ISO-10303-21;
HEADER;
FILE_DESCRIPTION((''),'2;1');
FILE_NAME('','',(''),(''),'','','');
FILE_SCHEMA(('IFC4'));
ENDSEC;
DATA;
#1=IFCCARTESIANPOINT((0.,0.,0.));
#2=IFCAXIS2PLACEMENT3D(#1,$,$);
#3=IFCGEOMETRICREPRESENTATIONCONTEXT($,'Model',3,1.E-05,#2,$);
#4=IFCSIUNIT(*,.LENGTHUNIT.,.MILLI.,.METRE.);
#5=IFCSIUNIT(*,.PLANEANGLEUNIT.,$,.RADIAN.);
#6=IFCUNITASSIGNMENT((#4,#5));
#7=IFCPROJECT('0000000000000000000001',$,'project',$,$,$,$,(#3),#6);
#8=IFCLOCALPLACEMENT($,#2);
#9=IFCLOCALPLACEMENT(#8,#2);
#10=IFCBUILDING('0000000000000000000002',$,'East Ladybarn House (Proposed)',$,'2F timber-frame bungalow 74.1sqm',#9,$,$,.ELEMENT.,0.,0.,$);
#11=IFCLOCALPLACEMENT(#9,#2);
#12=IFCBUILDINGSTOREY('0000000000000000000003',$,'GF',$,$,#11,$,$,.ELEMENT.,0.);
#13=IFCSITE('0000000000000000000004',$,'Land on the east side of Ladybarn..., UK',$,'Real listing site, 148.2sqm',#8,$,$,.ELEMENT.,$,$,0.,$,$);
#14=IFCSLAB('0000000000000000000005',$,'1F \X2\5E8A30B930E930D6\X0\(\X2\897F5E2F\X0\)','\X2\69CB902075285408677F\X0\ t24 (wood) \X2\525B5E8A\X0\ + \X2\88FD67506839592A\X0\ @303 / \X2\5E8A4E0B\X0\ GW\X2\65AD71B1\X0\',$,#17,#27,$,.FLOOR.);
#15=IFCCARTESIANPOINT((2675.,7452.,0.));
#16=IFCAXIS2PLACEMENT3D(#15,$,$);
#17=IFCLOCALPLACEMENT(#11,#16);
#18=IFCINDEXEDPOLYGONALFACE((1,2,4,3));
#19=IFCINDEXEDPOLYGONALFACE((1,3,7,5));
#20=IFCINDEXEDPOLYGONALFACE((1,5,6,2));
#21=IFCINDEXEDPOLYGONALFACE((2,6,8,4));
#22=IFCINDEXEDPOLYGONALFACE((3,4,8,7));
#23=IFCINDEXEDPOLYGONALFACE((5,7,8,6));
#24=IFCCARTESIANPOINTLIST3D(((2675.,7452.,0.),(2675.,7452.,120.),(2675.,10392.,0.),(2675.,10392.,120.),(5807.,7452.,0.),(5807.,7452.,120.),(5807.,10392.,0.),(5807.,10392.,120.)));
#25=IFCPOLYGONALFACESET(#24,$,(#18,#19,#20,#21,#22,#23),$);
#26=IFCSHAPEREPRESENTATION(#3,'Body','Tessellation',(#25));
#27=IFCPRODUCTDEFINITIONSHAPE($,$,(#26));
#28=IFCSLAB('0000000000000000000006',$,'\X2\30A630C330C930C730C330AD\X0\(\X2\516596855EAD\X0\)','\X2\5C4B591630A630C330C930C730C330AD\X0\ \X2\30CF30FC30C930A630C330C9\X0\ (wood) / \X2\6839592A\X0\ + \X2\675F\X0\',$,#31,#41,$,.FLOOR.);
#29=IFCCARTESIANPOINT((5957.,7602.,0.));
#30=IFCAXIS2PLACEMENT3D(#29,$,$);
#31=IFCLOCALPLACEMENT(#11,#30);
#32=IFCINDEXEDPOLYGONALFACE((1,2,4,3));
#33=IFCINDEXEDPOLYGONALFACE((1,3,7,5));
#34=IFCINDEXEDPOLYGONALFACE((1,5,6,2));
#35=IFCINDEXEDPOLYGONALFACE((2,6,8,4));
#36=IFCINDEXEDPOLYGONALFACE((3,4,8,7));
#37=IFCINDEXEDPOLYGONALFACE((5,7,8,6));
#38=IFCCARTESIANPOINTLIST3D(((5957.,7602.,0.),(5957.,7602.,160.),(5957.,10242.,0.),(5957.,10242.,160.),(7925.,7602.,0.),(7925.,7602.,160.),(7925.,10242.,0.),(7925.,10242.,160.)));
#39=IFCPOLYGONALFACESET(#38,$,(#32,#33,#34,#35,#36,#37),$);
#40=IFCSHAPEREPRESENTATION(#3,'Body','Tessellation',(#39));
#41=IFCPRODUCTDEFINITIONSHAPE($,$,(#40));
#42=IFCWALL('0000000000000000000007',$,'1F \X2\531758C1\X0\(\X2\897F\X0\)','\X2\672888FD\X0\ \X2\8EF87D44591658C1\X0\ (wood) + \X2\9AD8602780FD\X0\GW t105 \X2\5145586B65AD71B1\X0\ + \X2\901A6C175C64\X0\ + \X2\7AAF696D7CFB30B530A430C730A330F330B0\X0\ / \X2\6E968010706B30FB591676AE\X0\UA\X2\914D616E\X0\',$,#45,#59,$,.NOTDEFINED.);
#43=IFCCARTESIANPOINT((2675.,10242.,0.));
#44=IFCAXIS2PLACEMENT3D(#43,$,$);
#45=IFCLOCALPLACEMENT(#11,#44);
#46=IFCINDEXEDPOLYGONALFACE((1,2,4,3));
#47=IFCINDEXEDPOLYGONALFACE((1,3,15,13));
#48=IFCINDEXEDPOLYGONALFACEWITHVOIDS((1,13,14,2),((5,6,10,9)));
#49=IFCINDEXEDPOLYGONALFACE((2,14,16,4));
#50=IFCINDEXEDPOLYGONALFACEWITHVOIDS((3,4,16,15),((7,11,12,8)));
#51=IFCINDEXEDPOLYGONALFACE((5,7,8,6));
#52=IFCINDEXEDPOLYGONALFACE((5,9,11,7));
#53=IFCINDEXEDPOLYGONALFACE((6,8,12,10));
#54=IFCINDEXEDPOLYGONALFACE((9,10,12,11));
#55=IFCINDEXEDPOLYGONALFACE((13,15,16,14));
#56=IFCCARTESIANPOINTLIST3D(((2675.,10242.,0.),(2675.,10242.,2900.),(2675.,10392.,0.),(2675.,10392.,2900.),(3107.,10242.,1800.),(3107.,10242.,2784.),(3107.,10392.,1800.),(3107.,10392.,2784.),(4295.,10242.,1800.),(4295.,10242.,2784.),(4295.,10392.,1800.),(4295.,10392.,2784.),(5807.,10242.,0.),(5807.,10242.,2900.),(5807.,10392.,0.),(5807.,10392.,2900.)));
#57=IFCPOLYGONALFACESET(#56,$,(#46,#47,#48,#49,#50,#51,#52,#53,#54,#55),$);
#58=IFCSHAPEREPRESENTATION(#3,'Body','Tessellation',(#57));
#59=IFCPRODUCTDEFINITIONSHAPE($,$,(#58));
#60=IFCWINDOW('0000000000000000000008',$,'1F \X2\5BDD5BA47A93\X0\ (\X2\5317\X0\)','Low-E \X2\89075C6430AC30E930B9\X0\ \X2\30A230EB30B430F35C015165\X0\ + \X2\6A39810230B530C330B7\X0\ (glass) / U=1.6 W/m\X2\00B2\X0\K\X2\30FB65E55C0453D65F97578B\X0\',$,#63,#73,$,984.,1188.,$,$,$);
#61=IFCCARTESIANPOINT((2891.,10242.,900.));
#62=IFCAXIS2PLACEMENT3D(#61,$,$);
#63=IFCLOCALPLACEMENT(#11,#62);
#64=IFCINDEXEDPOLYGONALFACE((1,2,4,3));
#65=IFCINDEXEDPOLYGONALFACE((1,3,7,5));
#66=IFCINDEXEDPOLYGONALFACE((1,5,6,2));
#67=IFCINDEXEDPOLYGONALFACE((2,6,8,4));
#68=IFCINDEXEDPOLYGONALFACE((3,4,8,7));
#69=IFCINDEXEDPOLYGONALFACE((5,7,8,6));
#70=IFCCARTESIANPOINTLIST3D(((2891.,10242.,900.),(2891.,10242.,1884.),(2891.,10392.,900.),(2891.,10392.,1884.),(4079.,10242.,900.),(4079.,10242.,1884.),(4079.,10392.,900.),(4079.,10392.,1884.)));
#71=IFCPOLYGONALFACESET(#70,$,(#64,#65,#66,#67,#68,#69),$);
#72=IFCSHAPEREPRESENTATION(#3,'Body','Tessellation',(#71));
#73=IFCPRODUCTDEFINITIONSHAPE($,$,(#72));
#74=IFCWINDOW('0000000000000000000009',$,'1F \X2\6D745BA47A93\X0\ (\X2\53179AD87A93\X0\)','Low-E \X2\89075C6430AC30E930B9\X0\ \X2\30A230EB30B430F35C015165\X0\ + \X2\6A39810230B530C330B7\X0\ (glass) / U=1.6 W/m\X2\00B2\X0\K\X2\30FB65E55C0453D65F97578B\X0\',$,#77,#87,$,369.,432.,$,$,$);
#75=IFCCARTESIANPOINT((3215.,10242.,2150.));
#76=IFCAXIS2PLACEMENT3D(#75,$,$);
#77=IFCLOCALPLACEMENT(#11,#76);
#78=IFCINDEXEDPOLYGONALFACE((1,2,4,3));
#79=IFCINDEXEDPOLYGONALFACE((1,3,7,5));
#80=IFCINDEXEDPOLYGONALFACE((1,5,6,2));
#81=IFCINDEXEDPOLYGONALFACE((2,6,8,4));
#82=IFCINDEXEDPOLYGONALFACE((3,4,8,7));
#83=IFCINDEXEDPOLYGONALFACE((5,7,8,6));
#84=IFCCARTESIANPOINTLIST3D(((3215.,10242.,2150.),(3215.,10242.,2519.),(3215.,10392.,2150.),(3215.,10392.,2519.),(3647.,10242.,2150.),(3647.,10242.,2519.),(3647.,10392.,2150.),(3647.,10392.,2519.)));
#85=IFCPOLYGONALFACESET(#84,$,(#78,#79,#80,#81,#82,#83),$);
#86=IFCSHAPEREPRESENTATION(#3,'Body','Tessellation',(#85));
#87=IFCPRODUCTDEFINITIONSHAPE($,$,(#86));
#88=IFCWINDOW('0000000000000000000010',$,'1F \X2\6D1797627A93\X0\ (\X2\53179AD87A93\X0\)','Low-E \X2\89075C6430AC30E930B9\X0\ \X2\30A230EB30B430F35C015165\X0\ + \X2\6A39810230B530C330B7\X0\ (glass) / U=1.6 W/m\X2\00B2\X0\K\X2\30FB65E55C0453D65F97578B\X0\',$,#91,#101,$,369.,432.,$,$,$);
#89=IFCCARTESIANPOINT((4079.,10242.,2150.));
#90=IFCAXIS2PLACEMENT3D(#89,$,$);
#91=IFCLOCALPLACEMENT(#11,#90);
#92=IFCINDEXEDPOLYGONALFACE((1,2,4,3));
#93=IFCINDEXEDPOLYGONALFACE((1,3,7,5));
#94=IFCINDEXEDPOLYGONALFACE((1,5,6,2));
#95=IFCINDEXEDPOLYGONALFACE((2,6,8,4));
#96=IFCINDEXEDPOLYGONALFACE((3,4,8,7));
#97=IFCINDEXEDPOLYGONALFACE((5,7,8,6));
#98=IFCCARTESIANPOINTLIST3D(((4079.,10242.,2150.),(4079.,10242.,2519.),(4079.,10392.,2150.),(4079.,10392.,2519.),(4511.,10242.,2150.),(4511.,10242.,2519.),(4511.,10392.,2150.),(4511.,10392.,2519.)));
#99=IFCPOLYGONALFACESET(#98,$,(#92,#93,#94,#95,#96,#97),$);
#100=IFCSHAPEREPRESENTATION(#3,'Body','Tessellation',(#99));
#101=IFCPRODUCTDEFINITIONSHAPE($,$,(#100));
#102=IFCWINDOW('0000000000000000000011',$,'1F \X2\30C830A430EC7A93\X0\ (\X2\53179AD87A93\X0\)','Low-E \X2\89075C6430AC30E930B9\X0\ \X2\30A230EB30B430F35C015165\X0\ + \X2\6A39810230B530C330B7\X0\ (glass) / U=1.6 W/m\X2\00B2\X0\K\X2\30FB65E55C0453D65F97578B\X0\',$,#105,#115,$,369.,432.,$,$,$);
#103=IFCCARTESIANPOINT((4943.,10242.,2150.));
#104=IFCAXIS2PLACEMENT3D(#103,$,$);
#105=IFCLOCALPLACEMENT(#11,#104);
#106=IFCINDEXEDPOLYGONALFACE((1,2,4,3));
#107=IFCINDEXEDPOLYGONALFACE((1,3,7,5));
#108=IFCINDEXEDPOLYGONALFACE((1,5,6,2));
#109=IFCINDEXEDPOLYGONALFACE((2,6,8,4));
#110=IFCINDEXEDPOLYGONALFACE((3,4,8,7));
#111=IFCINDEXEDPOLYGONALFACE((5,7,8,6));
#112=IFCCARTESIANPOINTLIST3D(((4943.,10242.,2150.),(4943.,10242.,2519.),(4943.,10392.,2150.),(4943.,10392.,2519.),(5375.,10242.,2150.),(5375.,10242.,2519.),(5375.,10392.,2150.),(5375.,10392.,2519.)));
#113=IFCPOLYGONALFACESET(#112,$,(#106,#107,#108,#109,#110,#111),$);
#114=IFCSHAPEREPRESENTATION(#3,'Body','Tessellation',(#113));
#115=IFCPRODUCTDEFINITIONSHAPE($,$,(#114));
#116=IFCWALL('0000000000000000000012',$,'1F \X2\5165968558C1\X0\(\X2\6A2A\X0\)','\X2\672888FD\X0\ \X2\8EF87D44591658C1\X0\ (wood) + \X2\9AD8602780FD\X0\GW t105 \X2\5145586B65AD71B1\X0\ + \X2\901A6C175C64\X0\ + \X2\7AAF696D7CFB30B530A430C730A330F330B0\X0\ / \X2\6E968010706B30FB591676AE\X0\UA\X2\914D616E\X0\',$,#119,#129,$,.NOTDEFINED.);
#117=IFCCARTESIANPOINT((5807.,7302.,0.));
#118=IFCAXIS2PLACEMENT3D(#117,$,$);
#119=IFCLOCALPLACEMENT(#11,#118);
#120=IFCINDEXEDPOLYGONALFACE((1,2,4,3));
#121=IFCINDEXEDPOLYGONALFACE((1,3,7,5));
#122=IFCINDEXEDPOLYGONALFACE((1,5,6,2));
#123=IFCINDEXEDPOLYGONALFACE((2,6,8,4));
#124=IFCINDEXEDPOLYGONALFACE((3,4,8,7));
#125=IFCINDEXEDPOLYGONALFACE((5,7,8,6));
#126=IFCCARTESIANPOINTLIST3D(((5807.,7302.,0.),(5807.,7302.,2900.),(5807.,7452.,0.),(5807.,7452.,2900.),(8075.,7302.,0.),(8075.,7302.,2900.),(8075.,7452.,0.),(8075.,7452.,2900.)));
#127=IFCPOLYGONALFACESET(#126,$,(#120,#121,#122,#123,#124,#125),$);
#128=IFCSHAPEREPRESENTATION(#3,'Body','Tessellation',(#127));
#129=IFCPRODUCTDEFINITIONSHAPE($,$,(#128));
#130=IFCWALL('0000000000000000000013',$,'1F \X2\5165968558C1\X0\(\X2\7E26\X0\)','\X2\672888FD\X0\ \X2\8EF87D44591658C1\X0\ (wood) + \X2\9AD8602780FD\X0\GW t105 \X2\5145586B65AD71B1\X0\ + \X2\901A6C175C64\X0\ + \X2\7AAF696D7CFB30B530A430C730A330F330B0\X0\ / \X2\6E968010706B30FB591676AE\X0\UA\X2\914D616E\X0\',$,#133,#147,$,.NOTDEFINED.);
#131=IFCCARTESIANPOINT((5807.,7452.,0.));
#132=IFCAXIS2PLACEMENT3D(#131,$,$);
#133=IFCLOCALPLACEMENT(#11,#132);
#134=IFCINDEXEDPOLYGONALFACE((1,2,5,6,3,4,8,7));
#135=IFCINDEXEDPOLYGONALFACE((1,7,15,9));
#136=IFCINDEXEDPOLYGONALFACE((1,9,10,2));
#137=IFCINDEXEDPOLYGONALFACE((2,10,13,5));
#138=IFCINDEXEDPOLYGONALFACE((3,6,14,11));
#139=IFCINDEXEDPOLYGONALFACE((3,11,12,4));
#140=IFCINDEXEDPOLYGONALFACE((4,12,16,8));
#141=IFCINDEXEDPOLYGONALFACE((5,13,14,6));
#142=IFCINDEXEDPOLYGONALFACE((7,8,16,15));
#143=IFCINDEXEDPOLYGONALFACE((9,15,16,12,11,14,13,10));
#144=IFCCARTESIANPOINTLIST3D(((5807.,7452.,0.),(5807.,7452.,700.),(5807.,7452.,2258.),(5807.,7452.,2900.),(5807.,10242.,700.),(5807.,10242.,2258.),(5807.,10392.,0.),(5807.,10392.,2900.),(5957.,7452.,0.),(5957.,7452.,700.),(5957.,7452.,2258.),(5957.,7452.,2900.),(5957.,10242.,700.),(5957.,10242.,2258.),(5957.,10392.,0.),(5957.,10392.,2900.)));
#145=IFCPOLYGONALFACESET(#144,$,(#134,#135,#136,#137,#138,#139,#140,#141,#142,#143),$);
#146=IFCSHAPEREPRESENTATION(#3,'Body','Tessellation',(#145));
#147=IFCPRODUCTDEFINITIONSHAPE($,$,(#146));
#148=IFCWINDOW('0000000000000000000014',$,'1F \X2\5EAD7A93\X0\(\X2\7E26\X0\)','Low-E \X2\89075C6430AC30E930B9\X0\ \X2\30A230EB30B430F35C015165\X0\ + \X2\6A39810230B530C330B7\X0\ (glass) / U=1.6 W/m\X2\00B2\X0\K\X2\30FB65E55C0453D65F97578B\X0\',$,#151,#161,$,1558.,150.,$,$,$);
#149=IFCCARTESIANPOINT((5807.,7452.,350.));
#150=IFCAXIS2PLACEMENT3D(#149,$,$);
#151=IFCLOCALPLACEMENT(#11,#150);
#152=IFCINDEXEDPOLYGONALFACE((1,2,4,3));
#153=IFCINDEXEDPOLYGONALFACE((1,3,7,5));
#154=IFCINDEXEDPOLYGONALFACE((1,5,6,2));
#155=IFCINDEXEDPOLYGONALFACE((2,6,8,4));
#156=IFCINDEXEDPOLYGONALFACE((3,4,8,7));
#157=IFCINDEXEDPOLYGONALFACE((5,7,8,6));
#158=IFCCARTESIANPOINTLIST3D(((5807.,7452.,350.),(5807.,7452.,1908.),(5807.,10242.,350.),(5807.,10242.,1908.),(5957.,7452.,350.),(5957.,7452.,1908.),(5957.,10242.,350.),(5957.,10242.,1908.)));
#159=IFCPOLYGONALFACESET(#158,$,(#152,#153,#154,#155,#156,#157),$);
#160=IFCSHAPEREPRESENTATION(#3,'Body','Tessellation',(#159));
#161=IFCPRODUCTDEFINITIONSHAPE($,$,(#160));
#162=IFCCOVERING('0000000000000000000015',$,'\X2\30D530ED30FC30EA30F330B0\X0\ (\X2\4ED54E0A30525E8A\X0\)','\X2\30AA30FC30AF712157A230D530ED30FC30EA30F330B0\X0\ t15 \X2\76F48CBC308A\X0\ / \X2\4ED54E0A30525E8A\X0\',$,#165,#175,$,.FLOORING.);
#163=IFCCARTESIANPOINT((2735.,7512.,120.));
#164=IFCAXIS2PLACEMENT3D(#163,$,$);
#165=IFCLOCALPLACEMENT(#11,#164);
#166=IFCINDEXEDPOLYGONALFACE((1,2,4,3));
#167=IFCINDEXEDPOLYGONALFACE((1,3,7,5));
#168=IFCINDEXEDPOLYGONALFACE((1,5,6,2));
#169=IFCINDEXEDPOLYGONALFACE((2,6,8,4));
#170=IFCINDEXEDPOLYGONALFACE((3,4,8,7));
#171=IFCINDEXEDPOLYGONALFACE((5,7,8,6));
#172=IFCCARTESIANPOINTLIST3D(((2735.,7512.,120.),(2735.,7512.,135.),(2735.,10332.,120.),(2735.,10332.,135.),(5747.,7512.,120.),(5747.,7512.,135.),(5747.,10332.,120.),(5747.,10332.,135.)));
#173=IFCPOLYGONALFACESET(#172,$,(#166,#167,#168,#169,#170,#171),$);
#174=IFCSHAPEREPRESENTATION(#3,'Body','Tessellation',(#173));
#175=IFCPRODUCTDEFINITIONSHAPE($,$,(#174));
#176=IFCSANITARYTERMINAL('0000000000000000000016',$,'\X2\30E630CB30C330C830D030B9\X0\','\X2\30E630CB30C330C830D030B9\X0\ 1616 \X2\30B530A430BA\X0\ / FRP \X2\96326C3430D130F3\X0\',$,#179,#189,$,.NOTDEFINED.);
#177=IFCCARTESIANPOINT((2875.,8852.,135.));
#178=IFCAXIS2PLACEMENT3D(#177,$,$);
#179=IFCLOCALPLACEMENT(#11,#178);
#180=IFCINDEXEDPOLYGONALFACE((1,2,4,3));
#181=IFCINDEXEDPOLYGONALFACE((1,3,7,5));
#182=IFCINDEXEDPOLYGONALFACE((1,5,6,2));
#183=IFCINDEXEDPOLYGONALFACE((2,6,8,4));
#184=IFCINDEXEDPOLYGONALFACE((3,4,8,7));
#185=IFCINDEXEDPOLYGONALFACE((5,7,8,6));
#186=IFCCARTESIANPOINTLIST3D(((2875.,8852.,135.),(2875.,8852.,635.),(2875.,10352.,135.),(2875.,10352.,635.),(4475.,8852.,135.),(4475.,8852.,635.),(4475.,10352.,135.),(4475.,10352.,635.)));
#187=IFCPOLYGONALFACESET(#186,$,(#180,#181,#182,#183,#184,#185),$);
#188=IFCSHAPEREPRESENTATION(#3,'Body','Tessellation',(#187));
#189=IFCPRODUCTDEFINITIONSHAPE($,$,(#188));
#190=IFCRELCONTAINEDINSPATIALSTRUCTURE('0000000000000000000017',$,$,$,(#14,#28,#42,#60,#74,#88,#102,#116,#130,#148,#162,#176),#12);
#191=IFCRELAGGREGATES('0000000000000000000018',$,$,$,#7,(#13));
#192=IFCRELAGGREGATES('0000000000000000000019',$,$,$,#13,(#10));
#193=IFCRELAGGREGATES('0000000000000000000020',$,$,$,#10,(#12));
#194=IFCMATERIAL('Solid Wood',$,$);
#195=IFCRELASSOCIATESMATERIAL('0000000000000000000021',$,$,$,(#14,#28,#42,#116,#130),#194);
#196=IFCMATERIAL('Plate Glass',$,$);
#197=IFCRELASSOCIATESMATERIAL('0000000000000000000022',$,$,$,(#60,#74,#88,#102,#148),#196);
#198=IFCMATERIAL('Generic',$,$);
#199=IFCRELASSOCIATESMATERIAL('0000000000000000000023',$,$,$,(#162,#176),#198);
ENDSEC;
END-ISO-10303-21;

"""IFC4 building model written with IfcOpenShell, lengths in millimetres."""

from ifc_helpers import new_model, si_unit, frame, frame_2d, origin, place, context, project, spatial, rectangle, extrude, material, element, fill, save


model = new_model("IFC4")

# Units and contexts
model_context = context("Model", 3, precision=1e-05, world=origin())
ifc_project = project(units=[si_unit("LENGTHUNIT", "METRE", prefix="MILLI"), si_unit("PLANEANGLEUNIT", "RADIAN")], contexts=[model_context])

# Site, building, storey
site_placement = place(None, origin())
site = spatial("IfcSite", under=ifc_project, at=site_placement, Name="Land on the east side of Ladybarn..., UK", ObjectType="Real listing site, 148.2sqm", CompositionType="ELEMENT", RefElevation=0.0)
building_placement = place(site_placement, origin())
building = spatial("IfcBuilding", under=site, at=building_placement, Name="East Ladybarn House (Proposed)", ObjectType="2F timber-frame bungalow 74.1sqm", CompositionType="ELEMENT", ElevationOfRefHeight=0.0, ElevationOfTerrain=0.0)
storey_placement = place(building_placement, origin())
storey = spatial("IfcBuildingStorey", under=building, at=storey_placement, Name="GF", CompositionType="ELEMENT", Elevation=0.0)

# Slabs
ifc_material_1 = material(Name="Solid Wood")
slab_1_placement = place(storey_placement, frame((2675.0, 7452.0, 0.0)))
element("IfcSlab", 1, at=slab_1_placement, inside=storey, material=ifc_material_1, Name="1F 床スラブ(西帯)", Description="構造用合板 t24 (wood) 剛床 + 製材根太 @303 / 床下 GW断熱", PredefinedType="FLOOR", context=model_context, shape_type="SweptSolid", body=[
    extrude(rectangle(XDim=3132.0, YDim=2940.0, at=frame_2d((1566.0, 1470.0))), frame((2675.0, 7452.0, 0.0)), (0.0, 0.0, 1.0), 120.0),
])
slab_2_placement = place(storey_placement, frame((5957.0, 7602.0, 0.0)))
element("IfcSlab", 2, at=slab_2_placement, inside=storey, material=ifc_material_1, Name="ウッドデッキ(入隅庭)", Description="屋外ウッドデッキ ハードウッド (wood) / 根太 + 束", PredefinedType="FLOOR", context=model_context, shape_type="SweptSolid", body=[
    extrude(rectangle(XDim=1968.0, YDim=2640.0, at=frame_2d((984.0, 1320.0))), frame((5957.0, 7602.0, 0.0)), (0.0, 0.0, 1.0), 160.0),
])

# Wall, openings, windows
wall_1_placement = place(storey_placement, frame((2675.0, 10242.0, 0.0)))
wall_1 = element("IfcWall", 3, at=wall_1_placement, inside=storey, material=ifc_material_1, Name="1F 北壁(西)", Description="木製 軸組外壁 (wood) + 高性能GW t105 充填断熱 + 通気層 + 窯業系サイディング / 準耐火・外皮UA配慮", PredefinedType="NOTDEFINED", context=model_context, shape_type="SweptSolid", body=[
    extrude(rectangle(XDim=3132.0, YDim=150.0, at=frame_2d((1566.0, 75.0))), frame((2675.0, 10242.0, 0.0)), (0.0, 0.0, 1.0), 2900.0),
])
opening_1_placement = place(storey_placement, frame((2891.0, 10242.0, 900.0)))
opening_1 = element("IfcOpeningElement", 4, at=opening_1_placement, cuts=wall_1, PredefinedType="NOTDEFINED", context=model_context, shape_type="SweptSolid", body=[
    extrude(rectangle(XDim=1188.0, YDim=150.0, at=frame_2d((594.0, 75.0))), frame((2891.0, 10242.0, 900.0)), (0.0, 0.0, 1.0), 984.0),
])
opening_2_placement = place(storey_placement, frame((3215.0, 10242.0, 2150.0)))
opening_2 = element("IfcOpeningElement", 5, at=opening_2_placement, cuts=wall_1, PredefinedType="NOTDEFINED", context=model_context, shape_type="SweptSolid", body=[
    extrude(rectangle(XDim=432.0, YDim=150.0, at=frame_2d((216.0, 75.0))), frame((3215.0, 10242.0, 2150.0)), (0.0, 0.0, 1.0), 369.0),
])
opening_3_placement = place(storey_placement, frame((4079.0, 10242.0, 2150.0)))
opening_3 = element("IfcOpeningElement", 6, at=opening_3_placement, cuts=wall_1, PredefinedType="NOTDEFINED", context=model_context, shape_type="SweptSolid", body=[
    extrude(rectangle(XDim=432.0, YDim=150.0, at=frame_2d((216.0, 75.0))), frame((4079.0, 10242.0, 2150.0)), (0.0, 0.0, 1.0), 369.0),
])
opening_4_placement = place(storey_placement, frame((4943.0, 10242.0, 2150.0)))
opening_4 = element("IfcOpeningElement", 7, at=opening_4_placement, cuts=wall_1, PredefinedType="NOTDEFINED", context=model_context, shape_type="SweptSolid", body=[
    extrude(rectangle(XDim=432.0, YDim=150.0, at=frame_2d((216.0, 75.0))), frame((4943.0, 10242.0, 2150.0)), (0.0, 0.0, 1.0), 369.0),
])
ifc_material_2 = material(Name="Plate Glass")
window_1_placement = place(storey_placement, frame((2891.0, 10242.0, 900.0)))
window_1 = element("IfcWindow", 8, at=window_1_placement, inside=storey, material=ifc_material_2, Name="1F 寝室窓 (北)", Description="Low-E 複層ガラス アルゴン封入 + 樹脂サッシ (glass) / U=1.6 W/m²K・日射取得型", OverallHeight=984.0, OverallWidth=1188.0, context=model_context, shape_type="SweptSolid", body=[
    extrude(rectangle(XDim=1188.0, YDim=150.0, at=frame_2d((594.0, 75.0))), frame((2891.0, 10242.0, 900.0)), (0.0, 0.0, 1.0), 984.0),
])
fill(opening_1, window_1)
window_2_placement = place(storey_placement, frame((3215.0, 10242.0, 2150.0)))
window_2 = element("IfcWindow", 9, at=window_2_placement, inside=storey, material=ifc_material_2, Name="1F 浴室窓 (北高窓)", Description="Low-E 複層ガラス アルゴン封入 + 樹脂サッシ (glass) / U=1.6 W/m²K・日射取得型", OverallHeight=369.0, OverallWidth=432.0, context=model_context, shape_type="SweptSolid", body=[
    extrude(rectangle(XDim=432.0, YDim=150.0, at=frame_2d((216.0, 75.0))), frame((3215.0, 10242.0, 2150.0)), (0.0, 0.0, 1.0), 369.0),
])
fill(opening_2, window_2)
window_3_placement = place(storey_placement, frame((4079.0, 10242.0, 2150.0)))
window_3 = element("IfcWindow", 10, at=window_3_placement, inside=storey, material=ifc_material_2, Name="1F 洗面窓 (北高窓)", Description="Low-E 複層ガラス アルゴン封入 + 樹脂サッシ (glass) / U=1.6 W/m²K・日射取得型", OverallHeight=369.0, OverallWidth=432.0, context=model_context, shape_type="SweptSolid", body=[
    extrude(rectangle(XDim=432.0, YDim=150.0, at=frame_2d((216.0, 75.0))), frame((4079.0, 10242.0, 2150.0)), (0.0, 0.0, 1.0), 369.0),
])
fill(opening_3, window_3)
window_4_placement = place(storey_placement, frame((4943.0, 10242.0, 2150.0)))
window_4 = element("IfcWindow", 11, at=window_4_placement, inside=storey, material=ifc_material_2, Name="1F トイレ窓 (北高窓)", Description="Low-E 複層ガラス アルゴン封入 + 樹脂サッシ (glass) / U=1.6 W/m²K・日射取得型", OverallHeight=369.0, OverallWidth=432.0, context=model_context, shape_type="SweptSolid", body=[
    extrude(rectangle(XDim=432.0, YDim=150.0, at=frame_2d((216.0, 75.0))), frame((4943.0, 10242.0, 2150.0)), (0.0, 0.0, 1.0), 369.0),
])
fill(opening_4, window_4)

# Wall
wall_2_placement = place(storey_placement, frame((5807.0, 7302.0, 0.0)))
element("IfcWall", 12, at=wall_2_placement, inside=storey, material=ifc_material_1, Name="1F 入隅壁(横)", Description="木製 軸組外壁 (wood) + 高性能GW t105 充填断熱 + 通気層 + 窯業系サイディング / 準耐火・外皮UA配慮", PredefinedType="NOTDEFINED", context=model_context, shape_type="SweptSolid", body=[
    extrude(rectangle(XDim=2268.0, YDim=150.0, at=frame_2d((1134.0, 75.0))), frame((5807.0, 7302.0, 0.0)), (0.0, 0.0, 1.0), 2900.0),
])

# Wall, opening, window
wall_3_placement = place(storey_placement, frame((5807.0, 7452.0, 0.0)))
wall_3 = element("IfcWall", 13, at=wall_3_placement, inside=storey, material=ifc_material_1, Name="1F 入隅壁(縦)", Description="木製 軸組外壁 (wood) + 高性能GW t105 充填断熱 + 通気層 + 窯業系サイディング / 準耐火・外皮UA配慮", PredefinedType="NOTDEFINED", context=model_context, shape_type="SweptSolid", body=[
    extrude(rectangle(XDim=150.0, YDim=2940.0, at=frame_2d((75.0, 1470.0))), frame((5807.0, 7452.0, 0.0)), (0.0, 0.0, 1.0), 2900.0),
])
opening_5_placement = place(storey_placement, frame((5807.0, 7452.0, 350.0)))
opening_5 = element("IfcOpeningElement", 14, at=opening_5_placement, cuts=wall_3, PredefinedType="NOTDEFINED", context=model_context, shape_type="SweptSolid", body=[
    extrude(rectangle(XDim=150.0, YDim=2790.0, at=frame_2d((75.0, 1395.0))), frame((5807.0, 7452.0, 350.0)), (0.0, 0.0, 1.0), 1558.0),
])
window_5_placement = place(storey_placement, frame((5807.0, 7452.0, 350.0)))
window_5 = element("IfcWindow", 15, at=window_5_placement, inside=storey, material=ifc_material_2, Name="1F 庭窓(縦)", Description="Low-E 複層ガラス アルゴン封入 + 樹脂サッシ (glass) / U=1.6 W/m²K・日射取得型", OverallHeight=1558.0, OverallWidth=150.0, context=model_context, shape_type="SweptSolid", body=[
    extrude(rectangle(XDim=150.0, YDim=2790.0, at=frame_2d((75.0, 1395.0))), frame((5807.0, 7452.0, 350.0)), (0.0, 0.0, 1.0), 1558.0),
])
fill(opening_5, window_5)

# Covering
ifc_material_3 = material(Name="Generic")
covering_placement = place(storey_placement, frame((2735.0, 7512.0, 120.0)))
element("IfcCovering", 16, at=covering_placement, inside=storey, material=ifc_material_3, Name="フローリング (仕上げ床)", Description="オーク無垢フローリング t15 直貼り / 仕上げ床", PredefinedType="FLOORING", context=model_context, shape_type="SweptSolid", body=[
    extrude(rectangle(XDim=3012.0, YDim=2820.0, at=frame_2d((1506.0, 1410.0))), frame((2735.0, 7512.0, 120.0)), (0.0, 0.0, 1.0), 15.0),
])

# Sanitary terminal
sanitary_terminal_1_placement = place(storey_placement, frame((2875.0, 8852.0, 135.0)))
element("IfcSanitaryTerminal", 17, at=sanitary_terminal_1_placement, inside=storey, material=ifc_material_3, Name="ユニットバス", Description="ユニットバス 1616 サイズ / FRP 防水パン", PredefinedType="NOTDEFINED", context=model_context, shape_type="SweptSolid", body=[
    extrude(rectangle(XDim=1600.0, YDim=1500.0, at=frame_2d((800.0, 750.0))), frame((2875.0, 8852.0, 135.0)), (0.0, 0.0, 1.0), 500.0),
])

save(model, "model.ifc")
